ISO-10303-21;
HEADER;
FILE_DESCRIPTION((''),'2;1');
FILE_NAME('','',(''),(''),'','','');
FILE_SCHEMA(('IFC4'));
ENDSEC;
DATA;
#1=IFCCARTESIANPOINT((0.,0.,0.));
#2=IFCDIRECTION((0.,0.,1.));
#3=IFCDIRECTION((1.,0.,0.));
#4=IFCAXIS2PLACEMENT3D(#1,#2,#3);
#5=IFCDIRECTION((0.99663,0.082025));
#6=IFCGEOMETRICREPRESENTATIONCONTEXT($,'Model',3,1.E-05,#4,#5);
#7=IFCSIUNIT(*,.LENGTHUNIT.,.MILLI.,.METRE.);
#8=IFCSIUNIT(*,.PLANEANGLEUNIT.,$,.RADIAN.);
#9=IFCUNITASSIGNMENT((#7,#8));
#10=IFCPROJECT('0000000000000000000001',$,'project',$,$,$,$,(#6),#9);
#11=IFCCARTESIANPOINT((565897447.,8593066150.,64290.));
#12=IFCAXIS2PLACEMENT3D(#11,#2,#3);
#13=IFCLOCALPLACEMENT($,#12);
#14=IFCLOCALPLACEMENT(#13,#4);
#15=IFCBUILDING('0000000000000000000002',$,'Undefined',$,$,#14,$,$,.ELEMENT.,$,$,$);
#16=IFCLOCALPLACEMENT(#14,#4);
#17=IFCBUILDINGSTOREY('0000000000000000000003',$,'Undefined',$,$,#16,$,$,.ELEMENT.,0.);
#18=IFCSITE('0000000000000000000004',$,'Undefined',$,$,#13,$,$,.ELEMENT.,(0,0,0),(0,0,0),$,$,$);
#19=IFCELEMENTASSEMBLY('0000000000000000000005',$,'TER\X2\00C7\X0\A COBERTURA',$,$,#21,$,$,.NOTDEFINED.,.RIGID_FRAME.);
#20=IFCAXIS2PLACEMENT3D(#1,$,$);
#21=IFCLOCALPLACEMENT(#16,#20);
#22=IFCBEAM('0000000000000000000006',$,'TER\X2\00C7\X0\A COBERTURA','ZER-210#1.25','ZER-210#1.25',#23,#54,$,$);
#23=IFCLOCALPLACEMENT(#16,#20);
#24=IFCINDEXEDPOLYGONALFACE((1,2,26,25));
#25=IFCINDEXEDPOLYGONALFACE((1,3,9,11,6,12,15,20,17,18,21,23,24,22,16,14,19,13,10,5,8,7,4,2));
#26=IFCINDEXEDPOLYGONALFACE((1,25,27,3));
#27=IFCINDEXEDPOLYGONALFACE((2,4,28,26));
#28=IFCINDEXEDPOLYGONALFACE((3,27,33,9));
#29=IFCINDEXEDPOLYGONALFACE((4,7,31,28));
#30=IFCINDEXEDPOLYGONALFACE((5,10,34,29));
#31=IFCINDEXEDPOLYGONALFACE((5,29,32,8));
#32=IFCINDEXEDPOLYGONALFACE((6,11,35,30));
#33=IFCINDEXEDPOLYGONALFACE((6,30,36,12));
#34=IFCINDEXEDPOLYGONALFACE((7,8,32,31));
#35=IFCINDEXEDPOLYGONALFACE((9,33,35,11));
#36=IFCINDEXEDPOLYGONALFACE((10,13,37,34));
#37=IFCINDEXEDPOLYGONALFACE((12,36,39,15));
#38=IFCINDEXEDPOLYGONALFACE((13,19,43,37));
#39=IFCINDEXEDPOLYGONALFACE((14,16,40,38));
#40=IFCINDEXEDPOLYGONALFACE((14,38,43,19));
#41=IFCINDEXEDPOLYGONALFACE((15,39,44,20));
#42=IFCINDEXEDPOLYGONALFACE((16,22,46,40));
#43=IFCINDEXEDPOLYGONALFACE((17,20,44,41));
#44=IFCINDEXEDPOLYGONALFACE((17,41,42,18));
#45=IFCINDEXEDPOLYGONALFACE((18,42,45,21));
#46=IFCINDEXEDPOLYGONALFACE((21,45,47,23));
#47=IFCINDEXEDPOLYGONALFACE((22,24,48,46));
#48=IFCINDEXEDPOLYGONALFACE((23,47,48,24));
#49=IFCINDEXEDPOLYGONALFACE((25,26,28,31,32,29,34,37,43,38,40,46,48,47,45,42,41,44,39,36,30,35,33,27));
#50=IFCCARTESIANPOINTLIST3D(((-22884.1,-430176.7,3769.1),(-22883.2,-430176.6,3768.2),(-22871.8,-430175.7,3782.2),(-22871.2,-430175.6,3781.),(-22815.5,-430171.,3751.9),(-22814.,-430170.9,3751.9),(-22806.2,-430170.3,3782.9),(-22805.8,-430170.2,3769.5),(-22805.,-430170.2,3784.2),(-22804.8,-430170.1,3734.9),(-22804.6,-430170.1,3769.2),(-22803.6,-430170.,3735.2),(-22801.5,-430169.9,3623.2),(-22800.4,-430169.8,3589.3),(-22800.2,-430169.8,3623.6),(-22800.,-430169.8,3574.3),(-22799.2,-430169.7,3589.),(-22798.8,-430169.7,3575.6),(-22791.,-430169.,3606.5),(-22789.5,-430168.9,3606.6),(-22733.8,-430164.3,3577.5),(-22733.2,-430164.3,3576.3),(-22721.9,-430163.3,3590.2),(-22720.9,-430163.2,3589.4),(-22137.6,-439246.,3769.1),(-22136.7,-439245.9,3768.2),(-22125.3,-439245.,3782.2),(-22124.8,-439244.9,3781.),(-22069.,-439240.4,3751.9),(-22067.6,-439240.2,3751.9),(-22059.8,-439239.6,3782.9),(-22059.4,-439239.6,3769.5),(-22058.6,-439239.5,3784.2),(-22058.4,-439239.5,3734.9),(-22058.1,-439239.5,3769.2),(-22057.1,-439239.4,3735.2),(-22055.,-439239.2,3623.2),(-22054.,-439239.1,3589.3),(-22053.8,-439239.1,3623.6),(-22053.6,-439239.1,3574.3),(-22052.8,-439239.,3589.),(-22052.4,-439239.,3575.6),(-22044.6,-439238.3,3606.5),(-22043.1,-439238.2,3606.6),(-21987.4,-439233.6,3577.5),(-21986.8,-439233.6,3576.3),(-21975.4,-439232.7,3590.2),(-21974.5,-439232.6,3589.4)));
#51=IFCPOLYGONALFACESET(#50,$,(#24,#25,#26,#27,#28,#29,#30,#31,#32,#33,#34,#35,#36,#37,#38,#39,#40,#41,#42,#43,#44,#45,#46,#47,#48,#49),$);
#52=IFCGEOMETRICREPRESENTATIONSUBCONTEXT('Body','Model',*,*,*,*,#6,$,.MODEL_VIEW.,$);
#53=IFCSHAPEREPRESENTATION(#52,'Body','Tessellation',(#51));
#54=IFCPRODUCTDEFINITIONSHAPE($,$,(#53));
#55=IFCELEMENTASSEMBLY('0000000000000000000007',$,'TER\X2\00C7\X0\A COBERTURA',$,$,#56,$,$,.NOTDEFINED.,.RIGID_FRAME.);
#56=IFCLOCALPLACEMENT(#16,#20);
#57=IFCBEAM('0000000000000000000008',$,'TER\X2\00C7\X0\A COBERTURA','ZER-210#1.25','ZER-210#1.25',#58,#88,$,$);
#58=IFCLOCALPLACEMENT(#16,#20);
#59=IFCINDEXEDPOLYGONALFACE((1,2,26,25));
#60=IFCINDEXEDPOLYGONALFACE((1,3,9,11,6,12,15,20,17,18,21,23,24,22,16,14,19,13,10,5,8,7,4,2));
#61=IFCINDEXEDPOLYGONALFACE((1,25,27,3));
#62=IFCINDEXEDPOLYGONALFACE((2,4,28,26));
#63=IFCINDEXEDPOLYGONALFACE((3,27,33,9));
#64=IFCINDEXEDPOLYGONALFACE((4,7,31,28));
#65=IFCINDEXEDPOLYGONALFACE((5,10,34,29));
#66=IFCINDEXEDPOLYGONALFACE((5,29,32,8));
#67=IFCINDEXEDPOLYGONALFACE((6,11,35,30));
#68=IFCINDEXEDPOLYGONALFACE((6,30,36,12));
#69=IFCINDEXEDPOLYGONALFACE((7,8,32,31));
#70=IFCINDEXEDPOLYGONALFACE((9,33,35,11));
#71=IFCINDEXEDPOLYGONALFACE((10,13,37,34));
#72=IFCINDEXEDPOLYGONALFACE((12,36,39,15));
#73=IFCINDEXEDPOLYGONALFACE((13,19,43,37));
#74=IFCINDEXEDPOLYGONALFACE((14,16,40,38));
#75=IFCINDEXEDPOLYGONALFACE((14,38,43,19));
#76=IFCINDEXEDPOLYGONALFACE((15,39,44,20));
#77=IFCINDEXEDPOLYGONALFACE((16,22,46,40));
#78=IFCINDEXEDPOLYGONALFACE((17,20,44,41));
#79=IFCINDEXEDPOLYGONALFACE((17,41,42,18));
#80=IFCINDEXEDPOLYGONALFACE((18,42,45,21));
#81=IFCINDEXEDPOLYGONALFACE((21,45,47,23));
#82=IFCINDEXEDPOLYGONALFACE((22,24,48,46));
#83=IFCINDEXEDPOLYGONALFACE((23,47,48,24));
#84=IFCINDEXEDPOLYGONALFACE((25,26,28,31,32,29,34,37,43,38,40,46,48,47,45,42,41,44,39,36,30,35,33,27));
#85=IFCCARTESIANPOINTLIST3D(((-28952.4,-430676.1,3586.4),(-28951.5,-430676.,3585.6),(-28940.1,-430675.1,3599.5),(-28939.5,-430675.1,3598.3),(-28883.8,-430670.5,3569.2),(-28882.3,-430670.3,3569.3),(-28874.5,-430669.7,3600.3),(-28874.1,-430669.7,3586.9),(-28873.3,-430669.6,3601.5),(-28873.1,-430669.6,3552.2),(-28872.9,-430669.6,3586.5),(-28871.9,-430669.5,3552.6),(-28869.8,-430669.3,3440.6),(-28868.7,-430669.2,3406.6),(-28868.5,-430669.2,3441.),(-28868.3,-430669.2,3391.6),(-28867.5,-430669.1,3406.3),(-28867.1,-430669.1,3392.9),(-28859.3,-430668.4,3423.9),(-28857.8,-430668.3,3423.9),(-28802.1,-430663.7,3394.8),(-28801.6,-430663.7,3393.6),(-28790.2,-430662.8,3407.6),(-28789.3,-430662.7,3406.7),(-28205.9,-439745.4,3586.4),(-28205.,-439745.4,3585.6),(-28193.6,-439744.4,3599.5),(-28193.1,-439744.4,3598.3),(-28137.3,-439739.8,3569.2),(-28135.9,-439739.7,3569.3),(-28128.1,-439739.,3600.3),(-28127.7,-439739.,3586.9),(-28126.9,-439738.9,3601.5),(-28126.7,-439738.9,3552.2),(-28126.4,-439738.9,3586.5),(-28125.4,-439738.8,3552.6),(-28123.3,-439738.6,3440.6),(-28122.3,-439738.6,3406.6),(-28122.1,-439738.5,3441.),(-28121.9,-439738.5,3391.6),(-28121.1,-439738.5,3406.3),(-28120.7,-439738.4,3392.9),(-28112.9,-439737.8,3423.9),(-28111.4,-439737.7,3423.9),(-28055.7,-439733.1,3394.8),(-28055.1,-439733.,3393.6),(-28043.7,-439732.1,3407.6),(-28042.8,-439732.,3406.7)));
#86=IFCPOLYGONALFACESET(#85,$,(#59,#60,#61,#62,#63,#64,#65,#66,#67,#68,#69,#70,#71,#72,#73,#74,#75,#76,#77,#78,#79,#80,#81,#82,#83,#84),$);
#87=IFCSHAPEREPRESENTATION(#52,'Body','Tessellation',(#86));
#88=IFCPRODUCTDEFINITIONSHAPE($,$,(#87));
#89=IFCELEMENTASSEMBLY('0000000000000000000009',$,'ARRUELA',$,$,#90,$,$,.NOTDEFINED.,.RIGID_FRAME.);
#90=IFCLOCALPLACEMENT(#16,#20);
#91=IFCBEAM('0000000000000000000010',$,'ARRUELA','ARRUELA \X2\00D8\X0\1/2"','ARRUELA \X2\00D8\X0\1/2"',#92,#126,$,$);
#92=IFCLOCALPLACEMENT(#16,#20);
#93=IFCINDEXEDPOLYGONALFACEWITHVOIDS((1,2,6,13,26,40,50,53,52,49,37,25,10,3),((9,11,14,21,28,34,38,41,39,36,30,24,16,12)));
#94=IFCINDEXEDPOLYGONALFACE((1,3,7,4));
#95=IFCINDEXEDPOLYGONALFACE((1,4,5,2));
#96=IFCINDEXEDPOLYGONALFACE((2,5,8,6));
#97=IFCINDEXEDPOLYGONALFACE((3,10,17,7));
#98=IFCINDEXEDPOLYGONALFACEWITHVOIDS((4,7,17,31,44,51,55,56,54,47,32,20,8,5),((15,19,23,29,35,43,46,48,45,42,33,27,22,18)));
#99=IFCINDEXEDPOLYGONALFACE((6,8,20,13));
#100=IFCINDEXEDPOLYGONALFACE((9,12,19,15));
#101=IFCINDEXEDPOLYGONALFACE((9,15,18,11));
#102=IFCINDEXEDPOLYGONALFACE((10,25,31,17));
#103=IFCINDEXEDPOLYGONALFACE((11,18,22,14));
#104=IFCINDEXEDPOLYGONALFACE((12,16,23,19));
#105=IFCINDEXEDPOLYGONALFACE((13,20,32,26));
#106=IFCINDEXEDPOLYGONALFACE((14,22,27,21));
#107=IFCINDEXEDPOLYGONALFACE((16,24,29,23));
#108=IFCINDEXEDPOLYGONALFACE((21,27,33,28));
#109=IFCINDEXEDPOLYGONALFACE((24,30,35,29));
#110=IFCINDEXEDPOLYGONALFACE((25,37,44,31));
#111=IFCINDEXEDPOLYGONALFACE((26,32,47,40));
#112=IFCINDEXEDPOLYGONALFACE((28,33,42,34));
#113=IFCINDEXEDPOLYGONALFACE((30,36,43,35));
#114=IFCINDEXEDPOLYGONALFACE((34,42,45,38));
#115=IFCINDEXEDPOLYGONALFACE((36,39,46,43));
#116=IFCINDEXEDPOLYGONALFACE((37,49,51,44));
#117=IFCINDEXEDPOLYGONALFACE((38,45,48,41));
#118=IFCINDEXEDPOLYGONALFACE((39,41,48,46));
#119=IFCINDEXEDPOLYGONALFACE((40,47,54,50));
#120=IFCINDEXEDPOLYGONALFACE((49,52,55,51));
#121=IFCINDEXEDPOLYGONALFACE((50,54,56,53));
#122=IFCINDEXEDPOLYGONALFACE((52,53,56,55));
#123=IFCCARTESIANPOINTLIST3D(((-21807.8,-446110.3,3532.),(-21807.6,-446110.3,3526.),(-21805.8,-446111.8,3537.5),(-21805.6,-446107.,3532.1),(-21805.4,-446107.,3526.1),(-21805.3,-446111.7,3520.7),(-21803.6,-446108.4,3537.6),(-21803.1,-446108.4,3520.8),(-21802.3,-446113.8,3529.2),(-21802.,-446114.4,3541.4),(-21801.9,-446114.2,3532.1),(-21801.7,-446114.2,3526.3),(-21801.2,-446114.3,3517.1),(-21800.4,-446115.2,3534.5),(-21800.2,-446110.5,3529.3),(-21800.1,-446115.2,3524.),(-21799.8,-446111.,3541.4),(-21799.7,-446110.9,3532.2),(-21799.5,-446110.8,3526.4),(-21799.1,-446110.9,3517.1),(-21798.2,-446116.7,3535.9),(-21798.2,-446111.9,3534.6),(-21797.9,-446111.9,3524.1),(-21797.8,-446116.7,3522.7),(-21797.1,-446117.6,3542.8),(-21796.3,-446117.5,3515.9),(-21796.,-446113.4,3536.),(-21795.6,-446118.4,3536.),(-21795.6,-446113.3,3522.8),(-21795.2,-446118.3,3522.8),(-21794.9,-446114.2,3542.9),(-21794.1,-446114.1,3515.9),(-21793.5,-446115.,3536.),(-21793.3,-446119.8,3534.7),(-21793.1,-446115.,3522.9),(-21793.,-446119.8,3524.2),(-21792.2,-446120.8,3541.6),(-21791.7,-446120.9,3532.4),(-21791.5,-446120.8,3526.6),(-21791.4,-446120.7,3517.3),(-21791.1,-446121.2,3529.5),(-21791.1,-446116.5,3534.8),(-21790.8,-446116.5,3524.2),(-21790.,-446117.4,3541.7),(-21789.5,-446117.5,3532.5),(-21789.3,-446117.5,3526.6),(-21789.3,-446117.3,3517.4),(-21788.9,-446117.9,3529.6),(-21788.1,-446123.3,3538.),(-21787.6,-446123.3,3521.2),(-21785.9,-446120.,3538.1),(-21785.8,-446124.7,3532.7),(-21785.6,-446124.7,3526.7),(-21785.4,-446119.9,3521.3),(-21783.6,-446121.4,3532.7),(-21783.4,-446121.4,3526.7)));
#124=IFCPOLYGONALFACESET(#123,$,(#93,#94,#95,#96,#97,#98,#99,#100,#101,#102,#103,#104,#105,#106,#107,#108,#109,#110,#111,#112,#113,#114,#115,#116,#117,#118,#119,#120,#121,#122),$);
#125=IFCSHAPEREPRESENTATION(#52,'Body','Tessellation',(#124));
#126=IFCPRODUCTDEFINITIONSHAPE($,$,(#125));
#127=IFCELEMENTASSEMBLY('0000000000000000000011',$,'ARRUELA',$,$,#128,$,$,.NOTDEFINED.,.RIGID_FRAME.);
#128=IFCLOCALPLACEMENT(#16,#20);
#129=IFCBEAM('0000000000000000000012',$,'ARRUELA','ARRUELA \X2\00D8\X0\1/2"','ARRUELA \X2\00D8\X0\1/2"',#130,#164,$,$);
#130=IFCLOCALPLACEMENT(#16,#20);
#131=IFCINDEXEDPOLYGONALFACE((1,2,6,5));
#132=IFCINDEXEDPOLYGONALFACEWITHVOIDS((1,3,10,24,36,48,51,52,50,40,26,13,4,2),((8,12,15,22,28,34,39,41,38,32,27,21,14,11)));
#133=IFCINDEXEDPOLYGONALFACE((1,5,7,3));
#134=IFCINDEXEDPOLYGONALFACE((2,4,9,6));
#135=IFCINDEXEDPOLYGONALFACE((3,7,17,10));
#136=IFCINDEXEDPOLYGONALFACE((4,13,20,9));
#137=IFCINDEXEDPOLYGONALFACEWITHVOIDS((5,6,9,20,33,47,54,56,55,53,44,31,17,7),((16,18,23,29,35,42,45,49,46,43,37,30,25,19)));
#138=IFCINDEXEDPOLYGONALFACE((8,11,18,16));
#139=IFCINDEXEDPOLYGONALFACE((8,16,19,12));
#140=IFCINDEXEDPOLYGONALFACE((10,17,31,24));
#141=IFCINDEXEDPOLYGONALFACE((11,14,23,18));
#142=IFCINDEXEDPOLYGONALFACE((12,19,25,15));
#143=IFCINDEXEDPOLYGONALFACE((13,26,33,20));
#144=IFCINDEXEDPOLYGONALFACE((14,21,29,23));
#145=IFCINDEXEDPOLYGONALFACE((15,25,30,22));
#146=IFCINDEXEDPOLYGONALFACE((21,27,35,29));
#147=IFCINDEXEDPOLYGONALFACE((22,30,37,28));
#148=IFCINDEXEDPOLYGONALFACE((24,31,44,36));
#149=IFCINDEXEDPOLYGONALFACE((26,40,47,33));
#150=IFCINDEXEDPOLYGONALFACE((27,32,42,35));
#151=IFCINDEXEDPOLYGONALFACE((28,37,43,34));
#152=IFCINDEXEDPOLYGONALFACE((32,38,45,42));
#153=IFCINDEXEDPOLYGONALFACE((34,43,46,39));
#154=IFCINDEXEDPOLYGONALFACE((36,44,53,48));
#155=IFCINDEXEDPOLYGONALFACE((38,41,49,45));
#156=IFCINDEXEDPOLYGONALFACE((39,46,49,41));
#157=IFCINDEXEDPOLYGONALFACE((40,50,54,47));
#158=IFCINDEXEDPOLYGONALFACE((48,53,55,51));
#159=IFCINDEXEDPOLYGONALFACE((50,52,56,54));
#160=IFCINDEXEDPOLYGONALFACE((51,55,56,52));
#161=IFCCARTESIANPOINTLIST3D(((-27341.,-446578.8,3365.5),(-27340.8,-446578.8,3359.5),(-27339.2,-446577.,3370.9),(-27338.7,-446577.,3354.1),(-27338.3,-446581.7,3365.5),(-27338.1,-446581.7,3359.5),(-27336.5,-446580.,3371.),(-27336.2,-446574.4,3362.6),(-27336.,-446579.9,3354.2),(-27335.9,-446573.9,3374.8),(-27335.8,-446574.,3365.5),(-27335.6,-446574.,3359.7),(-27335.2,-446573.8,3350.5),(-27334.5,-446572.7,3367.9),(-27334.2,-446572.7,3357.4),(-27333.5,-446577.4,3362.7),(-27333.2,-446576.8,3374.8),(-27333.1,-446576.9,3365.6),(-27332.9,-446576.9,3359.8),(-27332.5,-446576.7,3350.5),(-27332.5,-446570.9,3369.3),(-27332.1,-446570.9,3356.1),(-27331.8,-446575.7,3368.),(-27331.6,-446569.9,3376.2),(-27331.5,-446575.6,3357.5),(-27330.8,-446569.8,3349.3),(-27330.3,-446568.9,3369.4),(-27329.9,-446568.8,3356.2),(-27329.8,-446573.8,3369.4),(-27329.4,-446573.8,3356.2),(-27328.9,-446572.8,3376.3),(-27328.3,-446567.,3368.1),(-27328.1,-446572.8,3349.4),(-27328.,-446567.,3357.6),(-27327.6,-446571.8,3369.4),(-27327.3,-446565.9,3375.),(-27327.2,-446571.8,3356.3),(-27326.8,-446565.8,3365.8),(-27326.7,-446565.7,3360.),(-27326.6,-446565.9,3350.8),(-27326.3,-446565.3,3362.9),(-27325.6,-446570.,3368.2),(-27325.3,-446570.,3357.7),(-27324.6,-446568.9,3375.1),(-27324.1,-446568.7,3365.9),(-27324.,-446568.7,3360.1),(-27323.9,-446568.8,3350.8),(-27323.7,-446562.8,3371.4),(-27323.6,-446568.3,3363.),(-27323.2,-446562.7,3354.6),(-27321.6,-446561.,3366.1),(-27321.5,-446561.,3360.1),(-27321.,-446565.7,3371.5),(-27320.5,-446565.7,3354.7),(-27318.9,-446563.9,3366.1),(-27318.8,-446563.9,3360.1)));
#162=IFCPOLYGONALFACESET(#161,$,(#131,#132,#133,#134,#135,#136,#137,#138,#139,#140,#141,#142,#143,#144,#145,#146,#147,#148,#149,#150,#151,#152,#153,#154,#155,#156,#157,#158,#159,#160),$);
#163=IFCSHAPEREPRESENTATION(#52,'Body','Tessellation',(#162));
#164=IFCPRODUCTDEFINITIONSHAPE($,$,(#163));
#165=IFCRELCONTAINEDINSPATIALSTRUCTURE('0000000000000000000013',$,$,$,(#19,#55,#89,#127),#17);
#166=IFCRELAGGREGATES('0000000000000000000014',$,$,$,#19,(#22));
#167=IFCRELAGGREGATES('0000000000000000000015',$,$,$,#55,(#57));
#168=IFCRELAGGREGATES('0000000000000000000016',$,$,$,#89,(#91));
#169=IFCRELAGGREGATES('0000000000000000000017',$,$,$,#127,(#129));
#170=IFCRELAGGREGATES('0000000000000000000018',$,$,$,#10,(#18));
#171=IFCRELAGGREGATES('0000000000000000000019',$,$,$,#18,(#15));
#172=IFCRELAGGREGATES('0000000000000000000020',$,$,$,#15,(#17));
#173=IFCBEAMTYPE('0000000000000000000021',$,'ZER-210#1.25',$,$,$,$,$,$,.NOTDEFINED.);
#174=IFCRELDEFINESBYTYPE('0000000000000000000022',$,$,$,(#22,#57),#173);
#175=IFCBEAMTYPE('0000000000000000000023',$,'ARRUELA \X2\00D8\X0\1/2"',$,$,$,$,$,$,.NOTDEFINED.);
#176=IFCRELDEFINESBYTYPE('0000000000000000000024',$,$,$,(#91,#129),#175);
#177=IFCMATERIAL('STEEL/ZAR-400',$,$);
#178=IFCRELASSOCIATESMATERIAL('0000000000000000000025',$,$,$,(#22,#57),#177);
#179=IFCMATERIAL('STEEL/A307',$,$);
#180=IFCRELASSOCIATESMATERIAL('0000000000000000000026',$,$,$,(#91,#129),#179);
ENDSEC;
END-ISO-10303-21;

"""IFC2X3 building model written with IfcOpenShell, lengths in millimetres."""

from ifc_helpers import new_model, si_unit, direction, frame, origin_with_axes, place, context, subcontext, project, spatial, polyline, outline, extrude, material, type_object, element, aggregate, save


model = new_model("IFC2X3")

# Units and contexts
model_context = context("Model", 3, precision=1e-05, world=origin_with_axes(), true_north=direction((0.99663, 0.082025)))
body_context = subcontext(model_context, "Body", "Model", "MODEL_VIEW")
ifc_project = project(units=[si_unit("LENGTHUNIT", "METRE", prefix="MILLI"), si_unit("PLANEANGLEUNIT", "RADIAN")], contexts=[model_context])

# Site, building, storey
site_placement = place(None, frame((565897447.0, 8593066150.0, 64290.0), z_axis=(0.0, 0.0, 1.0), x_axis=(1.0, 0.0, 0.0)))
site = spatial("IfcSite", under=ifc_project, at=site_placement, Name="Undefined", CompositionType="ELEMENT", RefLatitude=(0, 0, 0), RefLongitude=(0, 0, 0))
building_placement = place(site_placement, origin_with_axes())
building = spatial("IfcBuilding", under=site, at=building_placement, Name="Undefined", CompositionType="ELEMENT")
storey_placement = place(building_placement, origin_with_axes())
storey = spatial("IfcBuildingStorey", under=building, at=storey_placement, Name="Undefined", CompositionType="ELEMENT", Elevation=0.0)

# Element assemblies, beams
ifc_material_1 = material(Name="STEEL/ZAR-400")
beam_type_1 = type_object("IfcBeamType", Name="ZER-210#1.25", PredefinedType="NOTDEFINED")
assembly_1_placement = place(storey_placement, origin_with_axes())
assembly_1 = element("IfcElementAssembly", 1, at=assembly_1_placement, inside=storey, Name="TERÇA COBERTURA", AssemblyPlace="NOTDEFINED", PredefinedType="RIGID_FRAME")
beam_1_placement = place(assembly_1_placement, frame((-22056.1, -439239.3, 3679.2), z_axis=(-0.029885, -0.00246, 0.99955), x_axis=(-0.082025, 0.99663, 0.0)))
beam_1 = element("IfcBeam", 2, at=beam_1_placement, type_object=beam_type_1, material=ifc_material_1, Name="TERÇA COBERTURA", Description="ZER-210#1.25", ObjectType="ZER-210#1.25", context=body_context, shape_type="SweptSolid", body=[
    extrude(outline(polyline([(-65.9, 103.7), (-78.2, 91.4), (-79.1, 92.3), (-66.4, 105.0), (0.6, 105.0), (0.6, 90.0), (-9.4, 73.0), (0.6, 56.0), (0.6, -55.7), (10.8, -73.0), (0.6, -90.3), (0.6, -103.8), (65.9, -103.7), (78.2, -91.4), (79.1, -92.3), (66.4, -105.0), (-0.6, -105.0), (-0.6, -90.0), (9.4, -73.0), (-0.6, -56.0), (-0.6, 55.7), (-10.8, 73.0), (-0.6, 90.3), (-0.6, 103.8), (-65.9, 103.7)])), frame((9100.0, 0.0, 0.0), z_axis=(-1.0, 0.0, 0.0), x_axis=(0.0, -1.0, 0.0)), (0.0, 0.0, 1.0), 9100.0),
])
aggregate(assembly_1, [beam_1])
assembly_2_placement = place(storey_placement, origin_with_axes())
assembly_2 = element("IfcElementAssembly", 3, at=assembly_2_placement, inside=storey, Name="TERÇA COBERTURA", AssemblyPlace="NOTDEFINED", PredefinedType="RIGID_FRAME")
beam_2_placement = place(assembly_2_placement, frame((-28124.4, -439738.7, 3496.6), z_axis=(-0.029885, -0.00246, 0.99955), x_axis=(-0.082025, 0.99663, 0.0)))
beam_2 = element("IfcBeam", 4, at=beam_2_placement, type_object=beam_type_1, material=ifc_material_1, Name="TERÇA COBERTURA", Description="ZER-210#1.25", ObjectType="ZER-210#1.25", context=body_context, shape_type="SweptSolid", body=[
    extrude(outline(polyline([(-65.9, 103.7), (-78.2, 91.4), (-79.1, 92.3), (-66.4, 105.0), (0.6, 105.0), (0.6, 90.0), (-9.4, 73.0), (0.6, 56.0), (0.6, -55.7), (10.8, -73.0), (0.6, -90.3), (0.6, -103.8), (65.9, -103.7), (78.2, -91.4), (79.1, -92.3), (66.4, -105.0), (-0.6, -105.0), (-0.6, -90.0), (9.4, -73.0), (-0.6, -56.0), (-0.6, 55.7), (-10.8, 73.0), (-0.6, 90.3), (-0.6, 103.8), (-65.9, 103.7)])), frame((9100.0, 0.0, 0.0), z_axis=(-1.0, 0.0, 0.0), x_axis=(0.0, -1.0, 0.0)), (0.0, 0.0, 1.0), 9100.0),
])
aggregate(assembly_2, [beam_2])
assembly_3_placement = place(storey_placement, origin_with_axes())
assembly_3 = element("IfcElementAssembly", 5, at=assembly_3_placement, inside=storey, Name="ARRUELA", AssemblyPlace="NOTDEFINED", PredefinedType="RIGID_FRAME")
ifc_material_2 = material(Name="STEEL/A307")
beam_type_2 = type_object("IfcBeamType", Name="ARRUELA Ø1/2\"", PredefinedType="NOTDEFINED")
beam_3_placement = place(assembly_3_placement, frame((-21794.5, -446114.2, 3529.4), z_axis=(0.836984, -0.546715, 0.02368), x_axis=(-0.546411, -0.837315, -0.018398)))
beam_3 = element("IfcBeam", 6, at=beam_3_placement, type_object=beam_type_2, material=ifc_material_2, Name="ARRUELA", Description="ARRUELA Ø1/2\"", ObjectType="ARRUELA Ø1/2\"", context=body_context, shape_type="SweptSolid", body=[
    extrude(outline(polyline([(-12.2, 5.9), (-8.4, 10.5), (-3.0, 13.2), (3.0, 13.2), (8.4, 10.5), (12.2, 5.9), (13.5, 0.0), (12.2, -5.9), (8.4, -10.5), (3.0, -13.2), (-3.0, -13.2), (-8.4, -10.5), (-12.2, -5.9), (-13.5, 0.0), (-12.2, 5.9)]), holes=[polyline([(5.3, 4.2), (2.9, 6.1), (0.0, 6.8), (-2.9, 6.1), (-5.3, 4.2), (-6.6, 1.5), (-6.6, -1.5), (-5.3, -4.2), (-2.9, -6.1), (0.0, -6.7), (2.9, -6.1), (5.3, -4.2), (6.6, -1.5), (6.6, 1.5), (5.3, 4.2)])]), frame((4.0, 0.0, 0.0), z_axis=(-1.0, 0.0, 0.0), x_axis=(0.0, -1.0, 0.0)), (0.0, 0.0, 1.0), 4.0),
])
aggregate(assembly_3, [beam_3])
assembly_4_placement = place(storey_placement, origin_with_axes())
assembly_4 = element("IfcElementAssembly", 7, at=assembly_4_placement, inside=storey, Name="ARRUELA", AssemblyPlace="NOTDEFINED", PredefinedType="RIGID_FRAME")
beam_4_placement = place(assembly_4_placement, frame((-27331.2, -446569.9, 3362.8), z_axis=(0.736334, 0.676203, 0.02368), x_axis=(0.675958, -0.736711, 0.018398)))
beam_4 = element("IfcBeam", 8, at=beam_4_placement, type_object=beam_type_2, material=ifc_material_2, Name="ARRUELA", Description="ARRUELA Ø1/2\"", ObjectType="ARRUELA Ø1/2\"", context=body_context, shape_type="SweptSolid", body=[
    extrude(outline(polyline([(-12.2, 5.9), (-8.4, 10.5), (-3.0, 13.2), (3.0, 13.2), (8.4, 10.5), (12.2, 5.9), (13.5, 0.0), (12.2, -5.9), (8.4, -10.5), (3.0, -13.2), (-3.0, -13.2), (-8.4, -10.5), (-12.2, -5.9), (-13.5, 0.0), (-12.2, 5.9)]), holes=[polyline([(5.3, 4.2), (2.9, 6.1), (0.0, 6.8), (-2.9, 6.1), (-5.3, 4.2), (-6.6, 1.5), (-6.6, -1.5), (-5.3, -4.2), (-2.9, -6.1), (0.0, -6.7), (2.9, -6.1), (5.3, -4.2), (6.6, -1.5), (6.6, 1.5), (5.3, 4.2)])]), frame((4.0, 0.0, 0.0), z_axis=(-1.0, 0.0, 0.0), x_axis=(0.0, -1.0, 0.0)), (0.0, 0.0, 1.0), 4.0),
])
aggregate(assembly_4, [beam_4])

save(model, "model.ifc")
